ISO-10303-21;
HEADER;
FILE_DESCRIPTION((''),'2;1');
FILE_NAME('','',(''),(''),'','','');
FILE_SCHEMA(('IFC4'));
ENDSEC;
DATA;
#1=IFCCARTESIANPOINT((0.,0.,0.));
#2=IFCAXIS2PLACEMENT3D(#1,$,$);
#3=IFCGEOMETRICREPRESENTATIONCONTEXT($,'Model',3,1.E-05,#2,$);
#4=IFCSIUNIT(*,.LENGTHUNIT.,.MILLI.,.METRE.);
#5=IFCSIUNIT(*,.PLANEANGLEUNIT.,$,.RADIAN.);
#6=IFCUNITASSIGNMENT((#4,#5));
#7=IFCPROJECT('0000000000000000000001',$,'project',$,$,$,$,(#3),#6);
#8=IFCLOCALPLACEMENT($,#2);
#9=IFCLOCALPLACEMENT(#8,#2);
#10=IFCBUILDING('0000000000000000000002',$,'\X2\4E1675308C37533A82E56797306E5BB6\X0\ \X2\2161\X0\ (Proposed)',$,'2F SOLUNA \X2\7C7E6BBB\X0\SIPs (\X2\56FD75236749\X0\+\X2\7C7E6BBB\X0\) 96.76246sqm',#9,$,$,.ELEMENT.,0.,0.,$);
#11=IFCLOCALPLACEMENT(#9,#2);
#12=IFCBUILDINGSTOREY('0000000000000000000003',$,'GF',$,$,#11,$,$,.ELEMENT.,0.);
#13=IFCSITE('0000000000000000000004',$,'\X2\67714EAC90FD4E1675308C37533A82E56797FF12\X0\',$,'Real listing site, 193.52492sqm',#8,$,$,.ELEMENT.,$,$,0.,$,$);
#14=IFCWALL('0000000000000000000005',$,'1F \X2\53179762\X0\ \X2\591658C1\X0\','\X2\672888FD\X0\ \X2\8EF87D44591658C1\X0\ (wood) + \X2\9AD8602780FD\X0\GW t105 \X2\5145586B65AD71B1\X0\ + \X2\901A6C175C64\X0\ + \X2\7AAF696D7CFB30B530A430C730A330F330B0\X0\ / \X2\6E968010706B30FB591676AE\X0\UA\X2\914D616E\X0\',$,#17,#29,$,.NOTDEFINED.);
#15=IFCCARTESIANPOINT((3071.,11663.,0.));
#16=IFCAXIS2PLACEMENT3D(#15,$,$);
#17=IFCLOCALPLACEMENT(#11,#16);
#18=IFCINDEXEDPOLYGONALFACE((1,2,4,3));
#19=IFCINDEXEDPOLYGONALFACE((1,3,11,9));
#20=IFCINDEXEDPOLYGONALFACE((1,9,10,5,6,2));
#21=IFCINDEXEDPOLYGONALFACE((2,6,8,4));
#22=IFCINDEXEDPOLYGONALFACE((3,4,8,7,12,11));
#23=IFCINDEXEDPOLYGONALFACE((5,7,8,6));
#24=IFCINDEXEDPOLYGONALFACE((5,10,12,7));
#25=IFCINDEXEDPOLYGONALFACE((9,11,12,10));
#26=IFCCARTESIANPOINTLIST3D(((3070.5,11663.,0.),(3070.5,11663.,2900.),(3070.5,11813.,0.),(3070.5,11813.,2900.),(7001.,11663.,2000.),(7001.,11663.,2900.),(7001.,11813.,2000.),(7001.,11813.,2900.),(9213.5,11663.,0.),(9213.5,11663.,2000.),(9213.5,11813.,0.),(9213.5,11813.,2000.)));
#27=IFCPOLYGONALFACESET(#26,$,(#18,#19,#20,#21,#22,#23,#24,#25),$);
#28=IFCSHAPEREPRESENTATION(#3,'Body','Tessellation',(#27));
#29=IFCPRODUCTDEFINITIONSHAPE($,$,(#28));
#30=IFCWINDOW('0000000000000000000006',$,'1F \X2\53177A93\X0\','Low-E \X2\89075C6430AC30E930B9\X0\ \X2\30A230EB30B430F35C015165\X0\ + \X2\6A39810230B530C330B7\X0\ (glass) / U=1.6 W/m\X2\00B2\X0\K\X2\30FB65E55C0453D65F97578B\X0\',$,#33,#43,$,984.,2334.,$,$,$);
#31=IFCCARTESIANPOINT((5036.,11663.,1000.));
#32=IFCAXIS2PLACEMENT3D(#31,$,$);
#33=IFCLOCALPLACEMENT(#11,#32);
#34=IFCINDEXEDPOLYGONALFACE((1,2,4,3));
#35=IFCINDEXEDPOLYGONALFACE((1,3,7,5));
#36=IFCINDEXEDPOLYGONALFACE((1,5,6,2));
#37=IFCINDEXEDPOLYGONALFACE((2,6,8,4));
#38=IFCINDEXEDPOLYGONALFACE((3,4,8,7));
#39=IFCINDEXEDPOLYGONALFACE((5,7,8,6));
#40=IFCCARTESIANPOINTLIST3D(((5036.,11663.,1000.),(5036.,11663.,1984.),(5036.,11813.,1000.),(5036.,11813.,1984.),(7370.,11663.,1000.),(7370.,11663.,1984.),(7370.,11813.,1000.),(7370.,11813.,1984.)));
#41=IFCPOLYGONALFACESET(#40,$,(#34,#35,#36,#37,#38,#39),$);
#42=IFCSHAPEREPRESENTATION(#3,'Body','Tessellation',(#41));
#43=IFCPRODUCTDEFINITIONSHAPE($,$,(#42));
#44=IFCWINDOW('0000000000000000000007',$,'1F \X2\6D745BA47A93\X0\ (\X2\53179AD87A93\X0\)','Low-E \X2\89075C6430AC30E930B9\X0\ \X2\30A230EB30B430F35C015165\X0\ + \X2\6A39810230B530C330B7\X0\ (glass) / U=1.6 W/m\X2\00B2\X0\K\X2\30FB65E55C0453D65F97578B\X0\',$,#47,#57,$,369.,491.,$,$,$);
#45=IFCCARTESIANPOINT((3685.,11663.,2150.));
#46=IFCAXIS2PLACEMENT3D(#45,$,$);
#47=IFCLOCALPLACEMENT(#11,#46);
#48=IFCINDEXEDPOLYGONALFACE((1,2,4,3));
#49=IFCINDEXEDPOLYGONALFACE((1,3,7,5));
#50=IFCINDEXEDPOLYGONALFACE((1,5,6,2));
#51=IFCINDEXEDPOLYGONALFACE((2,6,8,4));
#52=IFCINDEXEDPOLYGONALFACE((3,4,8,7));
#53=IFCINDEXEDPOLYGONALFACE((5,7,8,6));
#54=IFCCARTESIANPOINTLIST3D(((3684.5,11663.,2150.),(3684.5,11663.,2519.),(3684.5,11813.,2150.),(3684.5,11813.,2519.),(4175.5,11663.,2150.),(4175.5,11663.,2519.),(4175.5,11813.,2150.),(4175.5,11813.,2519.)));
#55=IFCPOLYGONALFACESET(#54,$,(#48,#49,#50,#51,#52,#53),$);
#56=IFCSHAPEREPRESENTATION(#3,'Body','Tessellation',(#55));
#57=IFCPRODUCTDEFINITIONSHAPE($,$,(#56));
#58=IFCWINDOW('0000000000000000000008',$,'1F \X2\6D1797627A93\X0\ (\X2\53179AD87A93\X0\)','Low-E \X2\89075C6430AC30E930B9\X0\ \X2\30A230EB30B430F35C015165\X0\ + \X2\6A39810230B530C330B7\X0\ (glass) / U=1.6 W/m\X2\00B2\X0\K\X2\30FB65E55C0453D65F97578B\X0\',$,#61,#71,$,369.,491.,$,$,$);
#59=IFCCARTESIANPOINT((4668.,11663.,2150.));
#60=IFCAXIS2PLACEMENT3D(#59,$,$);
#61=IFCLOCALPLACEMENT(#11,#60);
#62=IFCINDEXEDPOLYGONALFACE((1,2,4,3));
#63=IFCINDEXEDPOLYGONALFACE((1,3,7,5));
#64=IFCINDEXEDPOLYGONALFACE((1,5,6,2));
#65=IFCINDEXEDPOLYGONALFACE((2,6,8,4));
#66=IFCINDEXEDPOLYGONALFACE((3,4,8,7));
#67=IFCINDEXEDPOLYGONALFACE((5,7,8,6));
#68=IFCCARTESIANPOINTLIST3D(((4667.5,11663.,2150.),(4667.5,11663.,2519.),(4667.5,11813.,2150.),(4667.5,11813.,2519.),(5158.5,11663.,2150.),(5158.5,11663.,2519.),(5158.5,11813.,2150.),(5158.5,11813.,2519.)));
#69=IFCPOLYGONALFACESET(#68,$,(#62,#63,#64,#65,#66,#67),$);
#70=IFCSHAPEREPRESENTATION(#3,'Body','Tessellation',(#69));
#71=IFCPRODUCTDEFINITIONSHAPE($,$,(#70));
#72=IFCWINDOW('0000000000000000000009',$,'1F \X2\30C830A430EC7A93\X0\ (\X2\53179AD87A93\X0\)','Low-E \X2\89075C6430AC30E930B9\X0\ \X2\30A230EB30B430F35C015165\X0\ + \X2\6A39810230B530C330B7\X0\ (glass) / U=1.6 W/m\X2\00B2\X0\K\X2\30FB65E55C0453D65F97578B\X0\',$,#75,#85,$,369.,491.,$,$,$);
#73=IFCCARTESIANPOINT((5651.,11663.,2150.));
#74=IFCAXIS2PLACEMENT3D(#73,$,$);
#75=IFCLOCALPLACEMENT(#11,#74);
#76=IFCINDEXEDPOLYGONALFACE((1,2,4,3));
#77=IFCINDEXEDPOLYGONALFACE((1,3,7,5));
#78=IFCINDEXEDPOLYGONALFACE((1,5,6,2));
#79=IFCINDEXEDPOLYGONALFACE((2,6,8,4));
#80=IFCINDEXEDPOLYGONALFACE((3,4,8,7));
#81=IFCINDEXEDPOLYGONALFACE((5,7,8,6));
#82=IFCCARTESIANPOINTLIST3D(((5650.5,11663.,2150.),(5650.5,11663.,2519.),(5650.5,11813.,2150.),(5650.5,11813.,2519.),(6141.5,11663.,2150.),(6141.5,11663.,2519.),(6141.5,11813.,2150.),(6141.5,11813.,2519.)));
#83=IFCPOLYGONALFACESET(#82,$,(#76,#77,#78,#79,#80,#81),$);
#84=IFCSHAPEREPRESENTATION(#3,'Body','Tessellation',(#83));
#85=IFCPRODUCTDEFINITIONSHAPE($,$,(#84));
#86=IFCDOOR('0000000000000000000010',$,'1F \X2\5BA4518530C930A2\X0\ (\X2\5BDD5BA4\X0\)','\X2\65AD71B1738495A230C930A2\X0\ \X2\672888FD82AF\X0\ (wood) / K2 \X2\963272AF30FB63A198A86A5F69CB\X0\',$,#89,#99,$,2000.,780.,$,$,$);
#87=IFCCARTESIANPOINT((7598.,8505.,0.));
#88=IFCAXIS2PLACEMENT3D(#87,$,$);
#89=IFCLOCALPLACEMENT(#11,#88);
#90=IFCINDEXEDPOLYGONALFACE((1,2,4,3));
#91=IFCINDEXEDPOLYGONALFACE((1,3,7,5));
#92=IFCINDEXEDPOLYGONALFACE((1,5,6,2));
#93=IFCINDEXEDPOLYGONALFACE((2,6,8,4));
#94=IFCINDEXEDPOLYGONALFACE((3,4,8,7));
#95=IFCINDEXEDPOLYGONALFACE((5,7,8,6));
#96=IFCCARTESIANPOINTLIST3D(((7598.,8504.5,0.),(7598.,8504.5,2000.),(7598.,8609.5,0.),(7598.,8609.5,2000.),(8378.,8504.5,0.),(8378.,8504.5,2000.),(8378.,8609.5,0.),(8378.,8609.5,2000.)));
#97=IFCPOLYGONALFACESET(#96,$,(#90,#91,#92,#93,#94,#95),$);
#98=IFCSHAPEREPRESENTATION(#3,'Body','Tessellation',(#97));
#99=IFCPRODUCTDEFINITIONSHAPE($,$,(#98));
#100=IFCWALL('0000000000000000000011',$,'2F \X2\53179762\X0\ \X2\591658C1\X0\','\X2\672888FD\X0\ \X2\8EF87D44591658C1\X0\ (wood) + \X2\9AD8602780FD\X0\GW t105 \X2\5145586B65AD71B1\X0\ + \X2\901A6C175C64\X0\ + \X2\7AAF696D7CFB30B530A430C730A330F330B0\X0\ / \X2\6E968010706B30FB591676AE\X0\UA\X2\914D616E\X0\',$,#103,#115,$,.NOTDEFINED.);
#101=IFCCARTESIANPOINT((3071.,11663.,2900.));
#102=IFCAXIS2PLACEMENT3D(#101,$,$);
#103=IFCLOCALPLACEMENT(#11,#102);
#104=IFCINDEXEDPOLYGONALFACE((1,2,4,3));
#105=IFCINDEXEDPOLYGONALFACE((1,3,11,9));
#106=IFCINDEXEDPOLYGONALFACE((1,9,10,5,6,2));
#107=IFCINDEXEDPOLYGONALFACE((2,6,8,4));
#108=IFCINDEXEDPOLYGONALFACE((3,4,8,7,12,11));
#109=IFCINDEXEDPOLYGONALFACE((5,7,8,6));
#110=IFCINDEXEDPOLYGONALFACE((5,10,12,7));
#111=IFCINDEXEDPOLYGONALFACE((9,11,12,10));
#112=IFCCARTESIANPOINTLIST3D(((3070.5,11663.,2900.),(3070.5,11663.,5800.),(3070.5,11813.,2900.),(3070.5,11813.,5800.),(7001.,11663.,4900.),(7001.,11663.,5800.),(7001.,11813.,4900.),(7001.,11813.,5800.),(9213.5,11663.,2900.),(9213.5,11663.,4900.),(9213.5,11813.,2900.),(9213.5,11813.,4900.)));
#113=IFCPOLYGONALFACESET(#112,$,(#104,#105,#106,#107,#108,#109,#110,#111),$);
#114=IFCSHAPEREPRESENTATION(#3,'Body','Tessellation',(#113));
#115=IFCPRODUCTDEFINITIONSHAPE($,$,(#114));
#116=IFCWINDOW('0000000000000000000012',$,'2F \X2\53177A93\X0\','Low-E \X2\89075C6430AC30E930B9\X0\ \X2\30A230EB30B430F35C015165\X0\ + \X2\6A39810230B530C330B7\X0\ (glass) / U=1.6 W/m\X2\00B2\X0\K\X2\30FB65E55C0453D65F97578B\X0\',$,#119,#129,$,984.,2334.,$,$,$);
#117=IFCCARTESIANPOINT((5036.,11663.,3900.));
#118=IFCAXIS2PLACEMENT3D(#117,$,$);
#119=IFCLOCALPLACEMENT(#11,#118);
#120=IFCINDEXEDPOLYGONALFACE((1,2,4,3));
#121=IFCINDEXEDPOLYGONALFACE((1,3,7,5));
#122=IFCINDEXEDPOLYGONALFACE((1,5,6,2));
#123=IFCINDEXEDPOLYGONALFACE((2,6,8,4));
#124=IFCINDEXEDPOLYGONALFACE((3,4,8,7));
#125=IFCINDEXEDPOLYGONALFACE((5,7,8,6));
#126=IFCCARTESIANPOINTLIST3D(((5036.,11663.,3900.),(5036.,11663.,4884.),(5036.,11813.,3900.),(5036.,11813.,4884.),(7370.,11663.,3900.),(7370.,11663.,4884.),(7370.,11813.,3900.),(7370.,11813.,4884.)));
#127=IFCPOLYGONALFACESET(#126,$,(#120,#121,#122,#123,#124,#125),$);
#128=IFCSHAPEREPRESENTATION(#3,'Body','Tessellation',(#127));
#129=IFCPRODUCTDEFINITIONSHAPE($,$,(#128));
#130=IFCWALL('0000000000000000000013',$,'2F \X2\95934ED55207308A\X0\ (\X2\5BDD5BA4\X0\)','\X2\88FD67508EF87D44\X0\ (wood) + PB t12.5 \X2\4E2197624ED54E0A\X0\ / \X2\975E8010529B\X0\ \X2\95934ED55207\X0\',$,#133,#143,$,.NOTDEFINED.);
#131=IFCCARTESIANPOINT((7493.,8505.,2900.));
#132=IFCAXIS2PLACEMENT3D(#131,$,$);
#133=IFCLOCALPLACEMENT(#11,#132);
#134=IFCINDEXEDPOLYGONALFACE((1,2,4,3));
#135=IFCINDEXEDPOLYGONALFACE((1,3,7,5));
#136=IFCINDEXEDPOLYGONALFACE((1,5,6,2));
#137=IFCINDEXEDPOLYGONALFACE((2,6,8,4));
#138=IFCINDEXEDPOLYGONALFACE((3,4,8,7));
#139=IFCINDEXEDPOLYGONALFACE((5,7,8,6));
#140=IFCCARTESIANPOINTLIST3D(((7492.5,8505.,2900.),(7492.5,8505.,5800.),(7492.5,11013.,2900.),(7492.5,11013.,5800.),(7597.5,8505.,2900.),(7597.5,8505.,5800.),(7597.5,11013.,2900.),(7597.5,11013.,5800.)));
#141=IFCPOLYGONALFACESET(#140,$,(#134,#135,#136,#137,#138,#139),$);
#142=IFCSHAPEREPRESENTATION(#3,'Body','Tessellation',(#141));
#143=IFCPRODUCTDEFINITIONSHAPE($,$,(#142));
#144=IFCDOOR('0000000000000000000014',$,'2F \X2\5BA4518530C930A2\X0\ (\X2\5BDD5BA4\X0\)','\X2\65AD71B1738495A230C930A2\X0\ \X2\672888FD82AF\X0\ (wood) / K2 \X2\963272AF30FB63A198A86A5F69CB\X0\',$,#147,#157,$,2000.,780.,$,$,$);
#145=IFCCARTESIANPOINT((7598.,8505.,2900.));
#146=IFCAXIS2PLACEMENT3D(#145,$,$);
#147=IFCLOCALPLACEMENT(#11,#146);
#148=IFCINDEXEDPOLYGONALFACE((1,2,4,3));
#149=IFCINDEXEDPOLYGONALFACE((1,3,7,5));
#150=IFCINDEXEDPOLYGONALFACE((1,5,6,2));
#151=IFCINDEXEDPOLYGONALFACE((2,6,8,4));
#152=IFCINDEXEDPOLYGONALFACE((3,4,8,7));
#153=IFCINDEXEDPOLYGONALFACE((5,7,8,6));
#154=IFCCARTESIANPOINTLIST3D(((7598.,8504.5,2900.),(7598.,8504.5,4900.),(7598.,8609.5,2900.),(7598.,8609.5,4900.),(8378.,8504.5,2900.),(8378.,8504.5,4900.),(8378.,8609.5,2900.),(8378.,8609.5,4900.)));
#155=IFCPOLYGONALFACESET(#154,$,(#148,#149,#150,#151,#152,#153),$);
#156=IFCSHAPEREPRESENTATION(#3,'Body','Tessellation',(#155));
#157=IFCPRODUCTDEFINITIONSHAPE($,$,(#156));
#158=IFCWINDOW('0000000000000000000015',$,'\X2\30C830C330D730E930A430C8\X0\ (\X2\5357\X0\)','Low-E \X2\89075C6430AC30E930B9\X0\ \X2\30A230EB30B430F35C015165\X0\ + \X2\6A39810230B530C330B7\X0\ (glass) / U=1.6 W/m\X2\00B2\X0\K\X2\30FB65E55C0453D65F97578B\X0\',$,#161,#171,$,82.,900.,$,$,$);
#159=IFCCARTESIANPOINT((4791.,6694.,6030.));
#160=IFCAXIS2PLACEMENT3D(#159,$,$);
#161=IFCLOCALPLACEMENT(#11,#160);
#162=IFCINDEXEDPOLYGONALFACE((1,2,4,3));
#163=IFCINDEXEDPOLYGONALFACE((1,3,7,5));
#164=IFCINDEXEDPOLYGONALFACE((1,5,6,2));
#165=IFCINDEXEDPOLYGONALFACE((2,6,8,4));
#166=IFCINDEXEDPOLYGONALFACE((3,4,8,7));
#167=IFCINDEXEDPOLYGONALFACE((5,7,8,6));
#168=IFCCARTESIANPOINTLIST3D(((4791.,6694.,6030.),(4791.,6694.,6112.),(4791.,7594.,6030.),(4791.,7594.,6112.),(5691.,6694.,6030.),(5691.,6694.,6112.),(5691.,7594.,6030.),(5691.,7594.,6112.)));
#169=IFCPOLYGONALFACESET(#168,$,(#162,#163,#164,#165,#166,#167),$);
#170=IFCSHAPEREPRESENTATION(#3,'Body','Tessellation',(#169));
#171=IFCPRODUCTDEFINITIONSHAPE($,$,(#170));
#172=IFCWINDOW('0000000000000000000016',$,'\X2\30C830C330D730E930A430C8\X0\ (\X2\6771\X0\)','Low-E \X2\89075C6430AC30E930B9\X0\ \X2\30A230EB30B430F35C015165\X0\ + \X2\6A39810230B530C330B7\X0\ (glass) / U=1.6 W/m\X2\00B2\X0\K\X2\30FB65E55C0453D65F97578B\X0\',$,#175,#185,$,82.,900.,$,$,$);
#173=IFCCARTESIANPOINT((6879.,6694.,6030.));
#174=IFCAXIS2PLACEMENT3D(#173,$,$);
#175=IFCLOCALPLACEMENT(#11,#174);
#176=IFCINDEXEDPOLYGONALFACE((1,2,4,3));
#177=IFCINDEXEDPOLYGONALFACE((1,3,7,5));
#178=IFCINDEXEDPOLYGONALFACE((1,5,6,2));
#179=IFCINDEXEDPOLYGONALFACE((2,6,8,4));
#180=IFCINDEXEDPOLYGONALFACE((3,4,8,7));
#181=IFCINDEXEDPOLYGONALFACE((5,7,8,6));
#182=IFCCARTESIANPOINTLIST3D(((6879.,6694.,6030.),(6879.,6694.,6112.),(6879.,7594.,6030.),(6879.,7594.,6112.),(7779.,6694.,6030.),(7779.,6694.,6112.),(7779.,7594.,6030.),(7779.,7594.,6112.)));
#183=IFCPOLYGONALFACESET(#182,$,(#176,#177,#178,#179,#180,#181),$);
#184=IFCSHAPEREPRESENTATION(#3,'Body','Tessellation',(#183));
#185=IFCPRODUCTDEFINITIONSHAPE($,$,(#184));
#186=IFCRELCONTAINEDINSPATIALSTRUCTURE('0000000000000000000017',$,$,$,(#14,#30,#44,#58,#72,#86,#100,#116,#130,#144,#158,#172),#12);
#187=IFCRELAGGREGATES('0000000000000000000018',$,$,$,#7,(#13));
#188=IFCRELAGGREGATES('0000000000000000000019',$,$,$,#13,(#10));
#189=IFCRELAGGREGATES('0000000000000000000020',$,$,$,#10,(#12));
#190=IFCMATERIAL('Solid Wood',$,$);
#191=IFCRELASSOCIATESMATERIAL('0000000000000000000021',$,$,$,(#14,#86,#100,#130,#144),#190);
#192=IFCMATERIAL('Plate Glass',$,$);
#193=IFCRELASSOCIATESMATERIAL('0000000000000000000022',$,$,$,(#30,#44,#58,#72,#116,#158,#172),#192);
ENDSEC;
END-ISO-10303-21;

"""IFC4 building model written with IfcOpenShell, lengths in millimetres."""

from ifc_helpers import new_model, si_unit, frame, frame_2d, origin, place, context, project, spatial, rectangle, extrude, material, element, fill, save


model = new_model("IFC4")

# Units and contexts
model_context = context("Model", 3, precision=1e-05, world=origin())
ifc_project = project(units=[si_unit("LENGTHUNIT", "METRE", prefix="MILLI"), si_unit("PLANEANGLEUNIT", "RADIAN")], contexts=[model_context])

# Site, building, storey
site_placement = place(None, origin())
site = spatial("IfcSite", under=ifc_project, at=site_placement, Name="東京都世田谷区若林２", ObjectType="Real listing site, 193.52492sqm", CompositionType="ELEMENT", RefElevation=0.0)
building_placement = place(site_placement, origin())
building = spatial("IfcBuilding", under=site, at=building_placement, Name="世田谷区若林の家 Ⅱ (Proposed)", ObjectType="2F SOLUNA 籾殻SIPs (国産杉+籾殻) 96.76246sqm", CompositionType="ELEMENT", ElevationOfRefHeight=0.0, ElevationOfTerrain=0.0)
storey_placement = place(building_placement, origin())
storey = spatial("IfcBuildingStorey", under=building, at=storey_placement, Name="GF", CompositionType="ELEMENT", Elevation=0.0)

# Wall, openings, windows
ifc_material_1 = material(Name="Solid Wood")
wall_1_placement = place(storey_placement, frame((3071.0, 11663.0, 0.0)))
wall_1 = element("IfcWall", 1, at=wall_1_placement, inside=storey, material=ifc_material_1, Name="1F 北面 外壁", Description="木製 軸組外壁 (wood) + 高性能GW t105 充填断熱 + 通気層 + 窯業系サイディング / 準耐火・外皮UA配慮", PredefinedType="NOTDEFINED", context=model_context, shape_type="SweptSolid", body=[
    extrude(rectangle(XDim=6143.0, YDim=150.0, at=frame_2d((3071.0, 75.0))), frame((3071.0, 11663.0, 0.0)), (0.0, 0.0, 1.0), 2900.0),
])
opening_1_placement = place(storey_placement, frame((5036.0, 11663.0, 1000.0)))
opening_1 = element("IfcOpeningElement", 2, at=opening_1_placement, cuts=wall_1, PredefinedType="NOTDEFINED", context=model_context, shape_type="SweptSolid", body=[
    extrude(rectangle(XDim=2334.0, YDim=150.0, at=frame_2d((1167.0, 75.0))), frame((5036.0, 11663.0, 1000.0)), (0.0, 0.0, 1.0), 984.0),
])
opening_2_placement = place(storey_placement, frame((3685.0, 11663.0, 2150.0)))
opening_2 = element("IfcOpeningElement", 3, at=opening_2_placement, cuts=wall_1, PredefinedType="NOTDEFINED", context=model_context, shape_type="SweptSolid", body=[
    extrude(rectangle(XDim=491.0, YDim=150.0, at=frame_2d((245.0, 75.0))), frame((3685.0, 11663.0, 2150.0)), (0.0, 0.0, 1.0), 369.0),
])
opening_3_placement = place(storey_placement, frame((4668.0, 11663.0, 2150.0)))
opening_3 = element("IfcOpeningElement", 4, at=opening_3_placement, cuts=wall_1, PredefinedType="NOTDEFINED", context=model_context, shape_type="SweptSolid", body=[
    extrude(rectangle(XDim=491.0, YDim=150.0, at=frame_2d((245.0, 75.0))), frame((4668.0, 11663.0, 2150.0)), (0.0, 0.0, 1.0), 369.0),
])
opening_4_placement = place(storey_placement, frame((5651.0, 11663.0, 2150.0)))
opening_4 = element("IfcOpeningElement", 5, at=opening_4_placement, cuts=wall_1, PredefinedType="NOTDEFINED", context=model_context, shape_type="SweptSolid", body=[
    extrude(rectangle(XDim=491.0, YDim=150.0, at=frame_2d((245.0, 75.0))), frame((5651.0, 11663.0, 2150.0)), (0.0, 0.0, 1.0), 369.0),
])
ifc_material_2 = material(Name="Plate Glass")
window_1_placement = place(storey_placement, frame((5036.0, 11663.0, 1000.0)))
window_1 = element("IfcWindow", 6, at=window_1_placement, inside=storey, material=ifc_material_2, Name="1F 北窓", Description="Low-E 複層ガラス アルゴン封入 + 樹脂サッシ (glass) / U=1.6 W/m²K・日射取得型", OverallHeight=984.0, OverallWidth=2334.0, context=model_context, shape_type="SweptSolid", body=[
    extrude(rectangle(XDim=2334.0, YDim=150.0, at=frame_2d((1167.0, 75.0))), frame((5036.0, 11663.0, 1000.0)), (0.0, 0.0, 1.0), 984.0),
])
fill(opening_1, window_1)
window_2_placement = place(storey_placement, frame((3685.0, 11663.0, 2150.0)))
window_2 = element("IfcWindow", 7, at=window_2_placement, inside=storey, material=ifc_material_2, Name="1F 浴室窓 (北高窓)", Description="Low-E 複層ガラス アルゴン封入 + 樹脂サッシ (glass) / U=1.6 W/m²K・日射取得型", OverallHeight=369.0, OverallWidth=491.0, context=model_context, shape_type="SweptSolid", body=[
    extrude(rectangle(XDim=491.0, YDim=150.0, at=frame_2d((245.0, 75.0))), frame((3685.0, 11663.0, 2150.0)), (0.0, 0.0, 1.0), 369.0),
])
fill(opening_2, window_2)
window_3_placement = place(storey_placement, frame((4668.0, 11663.0, 2150.0)))
window_3 = element("IfcWindow", 8, at=window_3_placement, inside=storey, material=ifc_material_2, Name="1F 洗面窓 (北高窓)", Description="Low-E 複層ガラス アルゴン封入 + 樹脂サッシ (glass) / U=1.6 W/m²K・日射取得型", OverallHeight=369.0, OverallWidth=491.0, context=model_context, shape_type="SweptSolid", body=[
    extrude(rectangle(XDim=491.0, YDim=150.0, at=frame_2d((245.0, 75.0))), frame((4668.0, 11663.0, 2150.0)), (0.0, 0.0, 1.0), 369.0),
])
fill(opening_3, window_3)
window_4_placement = place(storey_placement, frame((5651.0, 11663.0, 2150.0)))
window_4 = element("IfcWindow", 9, at=window_4_placement, inside=storey, material=ifc_material_2, Name="1F トイレ窓 (北高窓)", Description="Low-E 複層ガラス アルゴン封入 + 樹脂サッシ (glass) / U=1.6 W/m²K・日射取得型", OverallHeight=369.0, OverallWidth=491.0, context=model_context, shape_type="SweptSolid", body=[
    extrude(rectangle(XDim=491.0, YDim=150.0, at=frame_2d((245.0, 75.0))), frame((5651.0, 11663.0, 2150.0)), (0.0, 0.0, 1.0), 369.0),
])
fill(opening_4, window_4)

# Door
door_1_placement = place(storey_placement, frame((7598.0, 8505.0, 0.0)))
element("IfcDoor", 10, at=door_1_placement, inside=storey, material=ifc_material_1, Name="1F 室内ドア (寝室)", Description="断熱玄関ドア 木製芯 (wood) / K2 防犯・採風機構", OverallHeight=2000.0, OverallWidth=780.0, context=model_context, shape_type="SweptSolid", body=[
    extrude(rectangle(XDim=780.0, YDim=105.0, at=frame_2d((390.0, 52.0))), frame((7598.0, 8505.0, 0.0)), (0.0, 0.0, 1.0), 2000.0),
])

# Wall, opening, window
wall_2_placement = place(storey_placement, frame((3071.0, 11663.0, 2900.0)))
wall_2 = element("IfcWall", 11, at=wall_2_placement, inside=storey, material=ifc_material_1, Name="2F 北面 外壁", Description="木製 軸組外壁 (wood) + 高性能GW t105 充填断熱 + 通気層 + 窯業系サイディング / 準耐火・外皮UA配慮", PredefinedType="NOTDEFINED", context=model_context, shape_type="SweptSolid", body=[
    extrude(rectangle(XDim=6143.0, YDim=150.0, at=frame_2d((3071.0, 75.0))), frame((3071.0, 11663.0, 2900.0)), (0.0, 0.0, 1.0), 2900.0),
])
opening_5_placement = place(storey_placement, frame((5036.0, 11663.0, 3900.0)))
opening_5 = element("IfcOpeningElement", 12, at=opening_5_placement, cuts=wall_2, PredefinedType="NOTDEFINED", context=model_context, shape_type="SweptSolid", body=[
    extrude(rectangle(XDim=2334.0, YDim=150.0, at=frame_2d((1167.0, 75.0))), frame((5036.0, 11663.0, 3900.0)), (0.0, 0.0, 1.0), 984.0),
])
window_5_placement = place(storey_placement, frame((5036.0, 11663.0, 3900.0)))
window_5 = element("IfcWindow", 13, at=window_5_placement, inside=storey, material=ifc_material_2, Name="2F 北窓", Description="Low-E 複層ガラス アルゴン封入 + 樹脂サッシ (glass) / U=1.6 W/m²K・日射取得型", OverallHeight=984.0, OverallWidth=2334.0, context=model_context, shape_type="SweptSolid", body=[
    extrude(rectangle(XDim=2334.0, YDim=150.0, at=frame_2d((1167.0, 75.0))), frame((5036.0, 11663.0, 3900.0)), (0.0, 0.0, 1.0), 984.0),
])
fill(opening_5, window_5)

# Wall
wall_3_placement = place(storey_placement, frame((7493.0, 8505.0, 2900.0)))
element("IfcWall", 14, at=wall_3_placement, inside=storey, material=ifc_material_1, Name="2F 間仕切り (寝室)", Description="製材軸組 (wood) + PB t12.5 両面仕上 / 非耐力 間仕切", PredefinedType="NOTDEFINED", context=model_context, shape_type="SweptSolid", body=[
    extrude(rectangle(XDim=105.0, YDim=2508.0, at=frame_2d((52.0, 1254.0))), frame((7493.0, 8505.0, 2900.0)), (0.0, 0.0, 1.0), 2900.0),
])

# Door
door_2_placement = place(storey_placement, frame((7598.0, 8505.0, 2900.0)))
element("IfcDoor", 15, at=door_2_placement, inside=storey, material=ifc_material_1, Name="2F 室内ドア (寝室)", Description="断熱玄関ドア 木製芯 (wood) / K2 防犯・採風機構", OverallHeight=2000.0, OverallWidth=780.0, context=model_context, shape_type="SweptSolid", body=[
    extrude(rectangle(XDim=780.0, YDim=105.0, at=frame_2d((390.0, 52.0))), frame((7598.0, 8505.0, 2900.0)), (0.0, 0.0, 1.0), 2000.0),
])

# Windows
window_6_placement = place(storey_placement, frame((4791.0, 6694.0, 6030.0)))
element("IfcWindow", 16, at=window_6_placement, inside=storey, material=ifc_material_2, Name="トップライト (南)", Description="Low-E 複層ガラス アルゴン封入 + 樹脂サッシ (glass) / U=1.6 W/m²K・日射取得型", OverallHeight=82.0, OverallWidth=900.0, context=model_context, shape_type="SweptSolid", body=[
    extrude(rectangle(XDim=900.0, YDim=900.0, at=frame_2d((450.0, 450.0))), frame((4791.0, 6694.0, 6030.0)), (0.0, 0.0, 1.0), 82.0),
])
window_7_placement = place(storey_placement, frame((6879.0, 6694.0, 6030.0)))
element("IfcWindow", 17, at=window_7_placement, inside=storey, material=ifc_material_2, Name="トップライト (東)", Description="Low-E 複層ガラス アルゴン封入 + 樹脂サッシ (glass) / U=1.6 W/m²K・日射取得型", OverallHeight=82.0, OverallWidth=900.0, context=model_context, shape_type="SweptSolid", body=[
    extrude(rectangle(XDim=900.0, YDim=900.0, at=frame_2d((450.0, 450.0))), frame((6879.0, 6694.0, 6030.0)), (0.0, 0.0, 1.0), 82.0),
])

save(model, "model.ifc")
